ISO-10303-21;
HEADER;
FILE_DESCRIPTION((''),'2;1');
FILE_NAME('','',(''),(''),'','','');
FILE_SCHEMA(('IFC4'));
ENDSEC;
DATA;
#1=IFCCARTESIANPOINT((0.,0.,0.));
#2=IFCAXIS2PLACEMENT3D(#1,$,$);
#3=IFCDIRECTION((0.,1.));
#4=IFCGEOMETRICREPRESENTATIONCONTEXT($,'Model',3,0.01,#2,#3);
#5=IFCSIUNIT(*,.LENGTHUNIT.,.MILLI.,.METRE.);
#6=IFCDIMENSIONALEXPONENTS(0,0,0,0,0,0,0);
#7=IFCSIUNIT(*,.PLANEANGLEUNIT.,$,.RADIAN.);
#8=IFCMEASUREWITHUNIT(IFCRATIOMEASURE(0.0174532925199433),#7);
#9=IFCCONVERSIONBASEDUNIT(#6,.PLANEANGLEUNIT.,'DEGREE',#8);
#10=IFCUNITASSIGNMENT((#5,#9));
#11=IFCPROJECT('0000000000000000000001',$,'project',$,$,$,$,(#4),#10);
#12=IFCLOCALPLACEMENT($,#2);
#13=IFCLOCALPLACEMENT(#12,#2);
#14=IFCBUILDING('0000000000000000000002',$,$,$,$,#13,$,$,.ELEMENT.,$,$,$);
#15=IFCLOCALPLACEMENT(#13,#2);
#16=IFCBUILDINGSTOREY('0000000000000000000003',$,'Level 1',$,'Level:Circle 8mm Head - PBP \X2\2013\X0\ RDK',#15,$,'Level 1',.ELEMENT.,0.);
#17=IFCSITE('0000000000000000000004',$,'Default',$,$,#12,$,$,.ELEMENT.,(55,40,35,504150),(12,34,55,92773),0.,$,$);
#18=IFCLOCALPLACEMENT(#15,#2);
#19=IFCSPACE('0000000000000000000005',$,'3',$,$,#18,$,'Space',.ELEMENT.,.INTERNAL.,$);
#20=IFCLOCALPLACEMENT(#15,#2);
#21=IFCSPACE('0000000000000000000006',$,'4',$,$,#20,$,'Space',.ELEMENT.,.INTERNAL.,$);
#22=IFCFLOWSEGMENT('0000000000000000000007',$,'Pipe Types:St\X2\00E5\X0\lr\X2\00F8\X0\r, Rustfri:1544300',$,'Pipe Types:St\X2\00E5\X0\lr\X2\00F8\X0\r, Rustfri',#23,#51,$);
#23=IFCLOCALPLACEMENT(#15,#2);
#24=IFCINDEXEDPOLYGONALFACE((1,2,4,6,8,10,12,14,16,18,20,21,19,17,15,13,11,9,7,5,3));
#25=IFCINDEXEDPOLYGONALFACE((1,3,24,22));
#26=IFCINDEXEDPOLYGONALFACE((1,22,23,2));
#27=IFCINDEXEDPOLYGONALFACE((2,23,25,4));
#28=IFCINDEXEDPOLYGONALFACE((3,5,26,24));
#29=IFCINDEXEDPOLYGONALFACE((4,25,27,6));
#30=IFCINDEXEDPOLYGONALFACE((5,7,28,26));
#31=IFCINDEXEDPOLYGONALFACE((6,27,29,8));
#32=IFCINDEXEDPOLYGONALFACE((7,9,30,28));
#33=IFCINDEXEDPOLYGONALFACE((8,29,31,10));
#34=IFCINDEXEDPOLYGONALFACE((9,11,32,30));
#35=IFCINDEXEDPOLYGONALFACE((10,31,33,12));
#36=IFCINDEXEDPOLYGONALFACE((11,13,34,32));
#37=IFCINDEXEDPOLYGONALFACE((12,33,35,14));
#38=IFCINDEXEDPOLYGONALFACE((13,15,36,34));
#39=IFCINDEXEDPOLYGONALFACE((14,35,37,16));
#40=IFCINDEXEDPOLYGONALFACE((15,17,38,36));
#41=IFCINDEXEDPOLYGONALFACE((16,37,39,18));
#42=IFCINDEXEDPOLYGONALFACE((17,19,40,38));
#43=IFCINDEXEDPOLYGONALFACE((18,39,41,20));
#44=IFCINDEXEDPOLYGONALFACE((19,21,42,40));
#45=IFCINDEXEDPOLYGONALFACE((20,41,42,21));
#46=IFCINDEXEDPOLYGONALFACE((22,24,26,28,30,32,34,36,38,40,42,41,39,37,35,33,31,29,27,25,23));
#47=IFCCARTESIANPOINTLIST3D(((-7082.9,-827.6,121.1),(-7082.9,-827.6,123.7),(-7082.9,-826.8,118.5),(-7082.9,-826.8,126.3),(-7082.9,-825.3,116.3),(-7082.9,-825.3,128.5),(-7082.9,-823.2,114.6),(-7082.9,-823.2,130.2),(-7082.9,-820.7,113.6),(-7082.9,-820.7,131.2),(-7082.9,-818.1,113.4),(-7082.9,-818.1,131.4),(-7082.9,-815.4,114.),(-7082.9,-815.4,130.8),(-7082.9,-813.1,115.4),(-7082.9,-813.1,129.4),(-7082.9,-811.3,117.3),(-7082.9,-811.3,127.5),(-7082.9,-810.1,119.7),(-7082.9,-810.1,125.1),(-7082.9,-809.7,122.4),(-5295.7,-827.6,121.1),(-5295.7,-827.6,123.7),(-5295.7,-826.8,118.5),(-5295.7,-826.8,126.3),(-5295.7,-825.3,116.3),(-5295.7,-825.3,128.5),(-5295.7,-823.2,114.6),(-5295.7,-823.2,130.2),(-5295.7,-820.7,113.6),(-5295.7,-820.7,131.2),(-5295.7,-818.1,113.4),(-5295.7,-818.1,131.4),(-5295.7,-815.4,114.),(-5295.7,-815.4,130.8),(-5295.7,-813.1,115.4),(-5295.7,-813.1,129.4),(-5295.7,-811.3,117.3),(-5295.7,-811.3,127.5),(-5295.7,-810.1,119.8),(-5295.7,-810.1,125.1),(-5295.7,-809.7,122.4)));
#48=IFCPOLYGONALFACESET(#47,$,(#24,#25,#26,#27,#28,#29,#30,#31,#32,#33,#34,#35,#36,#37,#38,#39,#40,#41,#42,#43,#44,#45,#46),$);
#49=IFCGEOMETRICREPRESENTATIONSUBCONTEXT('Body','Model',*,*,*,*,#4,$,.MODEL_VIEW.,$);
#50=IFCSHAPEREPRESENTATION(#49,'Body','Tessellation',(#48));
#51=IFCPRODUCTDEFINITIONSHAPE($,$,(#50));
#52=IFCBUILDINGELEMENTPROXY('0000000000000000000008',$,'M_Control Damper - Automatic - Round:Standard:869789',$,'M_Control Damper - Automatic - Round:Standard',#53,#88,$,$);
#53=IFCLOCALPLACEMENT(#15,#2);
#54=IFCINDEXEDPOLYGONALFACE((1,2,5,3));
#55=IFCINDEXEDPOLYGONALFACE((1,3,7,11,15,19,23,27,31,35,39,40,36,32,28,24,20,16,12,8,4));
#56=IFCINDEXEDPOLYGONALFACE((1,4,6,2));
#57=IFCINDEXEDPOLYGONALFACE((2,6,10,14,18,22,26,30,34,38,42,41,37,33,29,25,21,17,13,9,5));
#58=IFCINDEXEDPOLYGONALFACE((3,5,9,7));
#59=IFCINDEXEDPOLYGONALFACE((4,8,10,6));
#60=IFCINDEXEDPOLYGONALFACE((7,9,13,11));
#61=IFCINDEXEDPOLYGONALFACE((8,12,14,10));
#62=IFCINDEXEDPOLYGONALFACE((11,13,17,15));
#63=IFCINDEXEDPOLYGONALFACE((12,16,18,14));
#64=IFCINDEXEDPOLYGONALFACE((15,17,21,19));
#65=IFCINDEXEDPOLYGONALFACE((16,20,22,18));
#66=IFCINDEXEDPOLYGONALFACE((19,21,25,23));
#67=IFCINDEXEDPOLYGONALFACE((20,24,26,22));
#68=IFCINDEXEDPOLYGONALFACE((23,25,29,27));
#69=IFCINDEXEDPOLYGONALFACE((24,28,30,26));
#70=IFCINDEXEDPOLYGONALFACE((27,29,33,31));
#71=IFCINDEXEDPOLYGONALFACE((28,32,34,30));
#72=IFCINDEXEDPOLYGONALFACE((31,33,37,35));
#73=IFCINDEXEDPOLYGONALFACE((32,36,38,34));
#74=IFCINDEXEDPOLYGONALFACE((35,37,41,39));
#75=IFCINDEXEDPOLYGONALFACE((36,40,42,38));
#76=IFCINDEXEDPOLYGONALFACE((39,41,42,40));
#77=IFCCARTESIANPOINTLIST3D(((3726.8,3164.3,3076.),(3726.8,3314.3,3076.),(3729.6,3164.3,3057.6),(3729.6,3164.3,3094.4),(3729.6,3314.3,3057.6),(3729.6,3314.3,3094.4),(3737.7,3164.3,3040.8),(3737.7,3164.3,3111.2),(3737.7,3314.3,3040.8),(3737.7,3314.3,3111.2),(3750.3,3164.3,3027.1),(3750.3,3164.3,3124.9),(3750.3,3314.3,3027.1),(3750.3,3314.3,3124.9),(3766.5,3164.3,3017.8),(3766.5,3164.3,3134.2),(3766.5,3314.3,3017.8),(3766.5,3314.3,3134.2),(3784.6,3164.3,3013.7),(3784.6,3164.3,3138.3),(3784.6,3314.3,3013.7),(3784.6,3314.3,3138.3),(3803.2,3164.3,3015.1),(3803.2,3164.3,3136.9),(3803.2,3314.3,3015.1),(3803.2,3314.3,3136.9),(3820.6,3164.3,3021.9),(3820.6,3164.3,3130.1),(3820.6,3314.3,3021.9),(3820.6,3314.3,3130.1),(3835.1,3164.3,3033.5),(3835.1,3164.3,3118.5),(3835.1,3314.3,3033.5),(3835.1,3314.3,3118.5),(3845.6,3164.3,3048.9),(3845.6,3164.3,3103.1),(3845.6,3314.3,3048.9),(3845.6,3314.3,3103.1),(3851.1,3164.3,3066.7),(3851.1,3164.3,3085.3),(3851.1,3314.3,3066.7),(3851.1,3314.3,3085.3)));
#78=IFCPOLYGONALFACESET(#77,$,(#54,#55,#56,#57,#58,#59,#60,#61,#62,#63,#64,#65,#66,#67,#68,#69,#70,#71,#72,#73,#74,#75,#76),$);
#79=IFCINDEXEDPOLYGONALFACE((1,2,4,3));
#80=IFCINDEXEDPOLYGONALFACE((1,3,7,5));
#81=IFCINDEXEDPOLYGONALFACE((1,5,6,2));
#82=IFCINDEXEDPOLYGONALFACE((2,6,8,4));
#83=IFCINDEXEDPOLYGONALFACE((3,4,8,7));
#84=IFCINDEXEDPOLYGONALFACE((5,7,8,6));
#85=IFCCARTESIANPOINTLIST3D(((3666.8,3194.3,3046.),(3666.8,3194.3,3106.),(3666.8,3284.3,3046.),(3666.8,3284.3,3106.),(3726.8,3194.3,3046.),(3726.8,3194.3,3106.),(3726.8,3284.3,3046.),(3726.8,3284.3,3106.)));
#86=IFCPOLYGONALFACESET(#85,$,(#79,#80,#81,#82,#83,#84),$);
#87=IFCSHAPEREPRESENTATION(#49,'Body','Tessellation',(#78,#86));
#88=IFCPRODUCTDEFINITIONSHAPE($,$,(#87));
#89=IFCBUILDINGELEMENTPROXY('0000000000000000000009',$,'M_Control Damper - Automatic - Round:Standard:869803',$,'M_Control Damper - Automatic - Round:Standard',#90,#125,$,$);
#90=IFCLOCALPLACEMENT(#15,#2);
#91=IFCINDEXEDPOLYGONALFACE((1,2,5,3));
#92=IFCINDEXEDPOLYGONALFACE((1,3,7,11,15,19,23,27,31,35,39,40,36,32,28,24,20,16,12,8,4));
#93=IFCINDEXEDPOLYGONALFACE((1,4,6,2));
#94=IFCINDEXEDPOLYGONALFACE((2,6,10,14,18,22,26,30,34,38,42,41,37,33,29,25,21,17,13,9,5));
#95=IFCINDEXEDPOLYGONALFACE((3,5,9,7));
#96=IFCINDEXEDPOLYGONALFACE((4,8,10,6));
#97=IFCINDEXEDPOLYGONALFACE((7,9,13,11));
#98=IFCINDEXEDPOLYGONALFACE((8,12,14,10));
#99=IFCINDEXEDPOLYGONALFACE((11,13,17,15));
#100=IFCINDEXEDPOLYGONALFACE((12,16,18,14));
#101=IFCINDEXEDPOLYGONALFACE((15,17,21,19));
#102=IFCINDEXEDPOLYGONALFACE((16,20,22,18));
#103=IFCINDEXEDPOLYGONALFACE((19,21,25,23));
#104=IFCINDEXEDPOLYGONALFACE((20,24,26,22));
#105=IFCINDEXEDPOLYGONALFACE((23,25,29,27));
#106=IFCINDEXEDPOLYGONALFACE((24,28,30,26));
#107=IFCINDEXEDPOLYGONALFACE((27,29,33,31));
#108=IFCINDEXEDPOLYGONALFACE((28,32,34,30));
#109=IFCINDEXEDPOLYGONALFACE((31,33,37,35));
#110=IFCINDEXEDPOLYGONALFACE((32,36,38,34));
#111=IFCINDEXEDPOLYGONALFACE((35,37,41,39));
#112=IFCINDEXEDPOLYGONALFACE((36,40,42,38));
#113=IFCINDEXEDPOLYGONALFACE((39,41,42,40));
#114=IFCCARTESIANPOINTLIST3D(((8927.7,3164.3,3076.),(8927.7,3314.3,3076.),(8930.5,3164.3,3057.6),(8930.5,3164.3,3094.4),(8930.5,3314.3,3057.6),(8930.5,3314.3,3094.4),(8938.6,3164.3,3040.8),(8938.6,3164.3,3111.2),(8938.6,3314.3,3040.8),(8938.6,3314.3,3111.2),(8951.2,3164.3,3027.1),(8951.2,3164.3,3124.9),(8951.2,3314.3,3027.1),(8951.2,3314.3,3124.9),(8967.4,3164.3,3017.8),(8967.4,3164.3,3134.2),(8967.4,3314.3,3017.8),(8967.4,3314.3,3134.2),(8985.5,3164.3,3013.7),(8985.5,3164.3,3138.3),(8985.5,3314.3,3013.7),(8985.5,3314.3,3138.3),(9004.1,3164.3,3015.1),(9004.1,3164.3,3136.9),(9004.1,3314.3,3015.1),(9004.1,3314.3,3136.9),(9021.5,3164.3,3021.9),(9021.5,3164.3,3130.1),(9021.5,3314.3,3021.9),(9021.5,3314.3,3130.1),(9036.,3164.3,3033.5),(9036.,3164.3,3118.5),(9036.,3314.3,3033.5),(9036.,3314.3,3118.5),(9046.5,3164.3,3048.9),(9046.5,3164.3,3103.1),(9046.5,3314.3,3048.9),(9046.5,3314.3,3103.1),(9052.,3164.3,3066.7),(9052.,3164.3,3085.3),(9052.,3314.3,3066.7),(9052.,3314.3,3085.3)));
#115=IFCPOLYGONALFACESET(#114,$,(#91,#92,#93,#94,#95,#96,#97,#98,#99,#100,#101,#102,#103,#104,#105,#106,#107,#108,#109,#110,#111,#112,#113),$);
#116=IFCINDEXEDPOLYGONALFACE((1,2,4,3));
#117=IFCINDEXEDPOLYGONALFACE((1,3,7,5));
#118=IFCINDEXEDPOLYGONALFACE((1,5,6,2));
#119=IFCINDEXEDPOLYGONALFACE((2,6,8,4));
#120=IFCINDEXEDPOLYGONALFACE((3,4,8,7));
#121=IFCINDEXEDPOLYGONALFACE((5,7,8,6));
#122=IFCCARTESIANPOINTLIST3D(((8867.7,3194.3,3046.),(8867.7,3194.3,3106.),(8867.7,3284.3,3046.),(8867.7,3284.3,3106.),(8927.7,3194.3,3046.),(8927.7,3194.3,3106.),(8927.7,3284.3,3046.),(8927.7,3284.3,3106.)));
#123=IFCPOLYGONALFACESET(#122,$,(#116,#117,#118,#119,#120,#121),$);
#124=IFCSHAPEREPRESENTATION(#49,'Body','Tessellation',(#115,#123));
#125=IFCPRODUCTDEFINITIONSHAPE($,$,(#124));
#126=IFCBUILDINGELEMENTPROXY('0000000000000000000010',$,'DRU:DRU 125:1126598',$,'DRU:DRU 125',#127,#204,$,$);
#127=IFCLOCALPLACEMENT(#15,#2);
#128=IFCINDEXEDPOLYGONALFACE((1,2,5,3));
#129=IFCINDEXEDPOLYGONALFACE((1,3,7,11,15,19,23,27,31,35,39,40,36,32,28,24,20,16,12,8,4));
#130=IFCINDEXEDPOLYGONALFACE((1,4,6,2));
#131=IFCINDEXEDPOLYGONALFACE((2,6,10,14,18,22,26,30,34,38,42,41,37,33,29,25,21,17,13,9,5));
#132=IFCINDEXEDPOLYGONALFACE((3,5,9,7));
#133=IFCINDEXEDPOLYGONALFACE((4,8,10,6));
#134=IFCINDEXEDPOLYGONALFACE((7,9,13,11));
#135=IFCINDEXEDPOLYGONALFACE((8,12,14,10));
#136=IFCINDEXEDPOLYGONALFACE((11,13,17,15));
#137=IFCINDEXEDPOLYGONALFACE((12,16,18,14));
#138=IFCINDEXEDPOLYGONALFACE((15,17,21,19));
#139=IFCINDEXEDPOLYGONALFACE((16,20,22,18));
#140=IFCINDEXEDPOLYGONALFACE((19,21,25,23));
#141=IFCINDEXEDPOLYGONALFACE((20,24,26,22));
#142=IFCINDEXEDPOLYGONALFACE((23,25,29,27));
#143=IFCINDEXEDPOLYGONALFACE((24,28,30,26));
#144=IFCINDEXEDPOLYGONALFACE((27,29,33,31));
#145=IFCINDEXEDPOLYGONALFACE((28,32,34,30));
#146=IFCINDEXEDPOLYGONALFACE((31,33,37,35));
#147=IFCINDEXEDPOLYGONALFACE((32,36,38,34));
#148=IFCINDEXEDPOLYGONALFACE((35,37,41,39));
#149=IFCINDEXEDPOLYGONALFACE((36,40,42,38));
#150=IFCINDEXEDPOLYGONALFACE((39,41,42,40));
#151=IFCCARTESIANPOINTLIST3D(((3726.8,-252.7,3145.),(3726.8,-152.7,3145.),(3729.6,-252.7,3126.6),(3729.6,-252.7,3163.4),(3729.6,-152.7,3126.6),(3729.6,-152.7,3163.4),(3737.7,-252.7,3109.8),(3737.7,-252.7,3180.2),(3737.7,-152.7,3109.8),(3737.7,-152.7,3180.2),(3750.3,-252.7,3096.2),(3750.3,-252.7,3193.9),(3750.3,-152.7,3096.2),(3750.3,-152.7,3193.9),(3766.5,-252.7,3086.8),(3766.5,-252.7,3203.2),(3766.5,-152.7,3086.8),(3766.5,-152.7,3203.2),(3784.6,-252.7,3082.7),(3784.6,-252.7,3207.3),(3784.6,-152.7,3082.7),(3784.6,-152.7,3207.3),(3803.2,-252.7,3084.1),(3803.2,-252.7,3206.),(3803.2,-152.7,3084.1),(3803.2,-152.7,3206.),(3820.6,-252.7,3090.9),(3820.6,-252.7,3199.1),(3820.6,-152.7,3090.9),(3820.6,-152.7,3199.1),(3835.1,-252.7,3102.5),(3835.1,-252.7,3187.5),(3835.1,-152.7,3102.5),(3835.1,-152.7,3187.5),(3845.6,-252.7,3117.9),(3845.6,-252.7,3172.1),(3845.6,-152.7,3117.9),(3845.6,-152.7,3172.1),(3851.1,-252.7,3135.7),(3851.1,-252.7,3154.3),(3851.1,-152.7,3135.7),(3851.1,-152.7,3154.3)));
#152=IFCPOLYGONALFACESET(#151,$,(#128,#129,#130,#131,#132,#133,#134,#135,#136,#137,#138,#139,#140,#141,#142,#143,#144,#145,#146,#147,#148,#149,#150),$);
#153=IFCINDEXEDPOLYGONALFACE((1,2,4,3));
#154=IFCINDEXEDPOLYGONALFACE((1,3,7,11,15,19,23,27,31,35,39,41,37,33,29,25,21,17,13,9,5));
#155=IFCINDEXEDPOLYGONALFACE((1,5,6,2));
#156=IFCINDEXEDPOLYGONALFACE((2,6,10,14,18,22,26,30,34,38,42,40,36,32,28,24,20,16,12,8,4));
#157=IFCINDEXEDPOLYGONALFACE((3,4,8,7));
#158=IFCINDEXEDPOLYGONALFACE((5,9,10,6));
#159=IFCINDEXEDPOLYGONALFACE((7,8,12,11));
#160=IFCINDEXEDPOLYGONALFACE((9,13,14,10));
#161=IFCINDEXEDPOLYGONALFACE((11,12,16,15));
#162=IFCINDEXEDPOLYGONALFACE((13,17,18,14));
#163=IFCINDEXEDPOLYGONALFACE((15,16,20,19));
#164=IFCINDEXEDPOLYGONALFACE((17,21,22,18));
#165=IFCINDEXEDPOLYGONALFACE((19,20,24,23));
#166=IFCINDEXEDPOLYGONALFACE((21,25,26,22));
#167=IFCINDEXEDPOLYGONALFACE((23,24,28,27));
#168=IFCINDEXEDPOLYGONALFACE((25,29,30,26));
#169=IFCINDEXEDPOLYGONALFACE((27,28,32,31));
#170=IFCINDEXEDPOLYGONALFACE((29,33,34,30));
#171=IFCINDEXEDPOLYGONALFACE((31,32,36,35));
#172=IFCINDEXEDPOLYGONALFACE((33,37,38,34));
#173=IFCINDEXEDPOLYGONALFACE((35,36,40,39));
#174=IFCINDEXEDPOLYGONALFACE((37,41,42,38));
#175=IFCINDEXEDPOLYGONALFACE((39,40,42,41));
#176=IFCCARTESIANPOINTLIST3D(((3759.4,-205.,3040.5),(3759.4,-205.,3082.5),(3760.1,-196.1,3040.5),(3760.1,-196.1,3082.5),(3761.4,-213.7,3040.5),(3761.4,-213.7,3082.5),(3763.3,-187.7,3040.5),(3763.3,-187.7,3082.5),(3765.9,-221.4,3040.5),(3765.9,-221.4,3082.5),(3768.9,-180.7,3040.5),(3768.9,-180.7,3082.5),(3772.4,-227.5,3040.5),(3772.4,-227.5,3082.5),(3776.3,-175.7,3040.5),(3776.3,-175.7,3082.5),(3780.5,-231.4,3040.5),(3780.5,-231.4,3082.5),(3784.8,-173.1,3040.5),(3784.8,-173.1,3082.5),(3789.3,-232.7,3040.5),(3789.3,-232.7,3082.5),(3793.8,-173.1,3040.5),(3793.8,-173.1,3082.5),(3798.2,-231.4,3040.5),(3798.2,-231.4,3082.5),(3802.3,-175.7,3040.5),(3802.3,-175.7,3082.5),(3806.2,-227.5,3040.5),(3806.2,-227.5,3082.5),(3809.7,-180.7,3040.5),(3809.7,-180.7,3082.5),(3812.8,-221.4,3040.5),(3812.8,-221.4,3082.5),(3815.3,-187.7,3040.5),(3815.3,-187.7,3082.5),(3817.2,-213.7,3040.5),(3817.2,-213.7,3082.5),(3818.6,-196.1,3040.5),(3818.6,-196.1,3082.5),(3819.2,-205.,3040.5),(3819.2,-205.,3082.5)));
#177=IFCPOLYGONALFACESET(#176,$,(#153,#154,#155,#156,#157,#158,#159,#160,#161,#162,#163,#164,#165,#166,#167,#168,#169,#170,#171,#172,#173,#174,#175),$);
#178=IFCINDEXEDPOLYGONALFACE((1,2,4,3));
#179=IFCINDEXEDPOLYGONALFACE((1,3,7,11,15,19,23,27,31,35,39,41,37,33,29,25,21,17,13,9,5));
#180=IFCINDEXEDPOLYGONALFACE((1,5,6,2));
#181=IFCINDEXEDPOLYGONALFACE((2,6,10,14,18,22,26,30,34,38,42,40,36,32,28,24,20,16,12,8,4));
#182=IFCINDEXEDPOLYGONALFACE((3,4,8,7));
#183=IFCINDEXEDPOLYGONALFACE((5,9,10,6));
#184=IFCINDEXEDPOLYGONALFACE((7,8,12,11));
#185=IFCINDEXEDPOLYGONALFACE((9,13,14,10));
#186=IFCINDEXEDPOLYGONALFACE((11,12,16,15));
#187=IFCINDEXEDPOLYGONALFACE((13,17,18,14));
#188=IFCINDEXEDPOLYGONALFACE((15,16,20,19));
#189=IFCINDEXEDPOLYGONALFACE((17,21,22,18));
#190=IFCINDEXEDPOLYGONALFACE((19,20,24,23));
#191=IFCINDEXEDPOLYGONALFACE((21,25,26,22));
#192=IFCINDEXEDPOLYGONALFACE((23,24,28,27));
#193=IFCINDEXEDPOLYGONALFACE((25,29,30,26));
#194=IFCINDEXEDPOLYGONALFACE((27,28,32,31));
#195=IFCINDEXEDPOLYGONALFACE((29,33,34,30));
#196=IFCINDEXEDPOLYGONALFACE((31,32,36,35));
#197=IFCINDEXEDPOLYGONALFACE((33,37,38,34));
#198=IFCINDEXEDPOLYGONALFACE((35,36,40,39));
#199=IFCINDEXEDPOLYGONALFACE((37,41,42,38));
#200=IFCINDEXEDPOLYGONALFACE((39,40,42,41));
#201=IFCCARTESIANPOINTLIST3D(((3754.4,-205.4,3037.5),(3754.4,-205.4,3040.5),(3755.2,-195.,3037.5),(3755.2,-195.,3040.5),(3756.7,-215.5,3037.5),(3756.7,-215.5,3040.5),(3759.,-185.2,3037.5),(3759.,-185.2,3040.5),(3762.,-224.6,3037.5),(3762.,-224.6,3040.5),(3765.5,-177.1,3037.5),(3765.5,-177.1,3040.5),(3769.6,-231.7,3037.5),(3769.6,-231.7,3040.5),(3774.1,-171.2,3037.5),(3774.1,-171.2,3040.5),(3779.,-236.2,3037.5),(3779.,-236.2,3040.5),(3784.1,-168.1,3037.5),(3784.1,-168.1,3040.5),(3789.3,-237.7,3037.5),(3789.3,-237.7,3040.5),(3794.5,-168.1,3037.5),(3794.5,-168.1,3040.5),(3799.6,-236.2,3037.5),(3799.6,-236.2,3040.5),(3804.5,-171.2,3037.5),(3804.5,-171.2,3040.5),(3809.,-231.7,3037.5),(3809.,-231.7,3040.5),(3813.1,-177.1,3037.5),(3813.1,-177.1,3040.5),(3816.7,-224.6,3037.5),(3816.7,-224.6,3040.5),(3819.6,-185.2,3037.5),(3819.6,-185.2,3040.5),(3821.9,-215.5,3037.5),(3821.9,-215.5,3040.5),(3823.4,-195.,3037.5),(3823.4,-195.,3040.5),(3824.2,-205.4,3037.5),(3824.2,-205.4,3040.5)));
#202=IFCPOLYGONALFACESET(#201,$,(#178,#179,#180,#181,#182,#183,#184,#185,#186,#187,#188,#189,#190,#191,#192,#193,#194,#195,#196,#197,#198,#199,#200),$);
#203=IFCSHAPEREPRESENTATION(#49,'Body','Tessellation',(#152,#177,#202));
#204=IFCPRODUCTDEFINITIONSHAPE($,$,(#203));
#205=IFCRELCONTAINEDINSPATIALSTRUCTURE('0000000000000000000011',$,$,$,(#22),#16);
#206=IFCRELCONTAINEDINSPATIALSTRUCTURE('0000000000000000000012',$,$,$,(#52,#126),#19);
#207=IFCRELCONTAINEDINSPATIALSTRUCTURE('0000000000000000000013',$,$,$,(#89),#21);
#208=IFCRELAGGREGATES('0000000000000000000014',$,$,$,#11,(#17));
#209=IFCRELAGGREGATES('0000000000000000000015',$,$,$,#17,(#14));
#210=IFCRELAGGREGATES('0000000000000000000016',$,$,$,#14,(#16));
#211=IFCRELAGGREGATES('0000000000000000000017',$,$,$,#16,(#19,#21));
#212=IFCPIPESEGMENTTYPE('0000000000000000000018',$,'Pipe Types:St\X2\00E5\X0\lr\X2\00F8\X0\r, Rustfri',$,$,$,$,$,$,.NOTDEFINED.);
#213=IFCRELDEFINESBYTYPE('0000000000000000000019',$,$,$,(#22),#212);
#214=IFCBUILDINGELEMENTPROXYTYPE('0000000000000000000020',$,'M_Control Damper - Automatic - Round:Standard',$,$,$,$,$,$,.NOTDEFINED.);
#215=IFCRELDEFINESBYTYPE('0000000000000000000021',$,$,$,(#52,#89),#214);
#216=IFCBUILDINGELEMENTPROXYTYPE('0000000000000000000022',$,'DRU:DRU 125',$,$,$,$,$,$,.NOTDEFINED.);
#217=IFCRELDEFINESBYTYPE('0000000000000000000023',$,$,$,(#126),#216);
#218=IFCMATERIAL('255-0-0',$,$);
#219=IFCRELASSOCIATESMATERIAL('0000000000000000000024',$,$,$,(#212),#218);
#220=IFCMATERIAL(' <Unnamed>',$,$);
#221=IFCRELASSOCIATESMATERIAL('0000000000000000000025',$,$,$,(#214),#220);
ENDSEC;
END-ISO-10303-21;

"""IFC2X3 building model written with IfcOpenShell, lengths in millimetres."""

from ifc_helpers import new_model, entity, si_unit, converted_unit, direction, frame, frame_2d, origin, place, context, subcontext, project, spatial, rectangle, circle, extrude, source, transform, mapped, material, type_object, type_shapes, element, save


model = new_model("IFC2X3")

# Units and contexts
model_context = context("Model", 3, precision=0.01, world=origin(), true_north=direction((0.0, 1.0)))
body_context = subcontext(model_context, "Body", "Model", "MODEL_VIEW")
ifc_project = project(units=[si_unit("LENGTHUNIT", "METRE", prefix="MILLI"), converted_unit("PLANEANGLEUNIT", "DEGREE", entity("IfcRatioMeasure", 0.0174532925199433), si_unit("PLANEANGLEUNIT", "RADIAN"), dimensions=[0, 0, 0, 0, 0, 0, 0])], contexts=[model_context])

# Site, building, storey, space
site_placement = place(None, origin())
site = spatial("IfcSite", under=ifc_project, at=site_placement, Name="Default", CompositionType="ELEMENT", RefLatitude=(55, 40, 35, 504150), RefLongitude=(12, 34, 55, 92773), RefElevation=0.0)
building_placement = place(site_placement, origin())
building = spatial("IfcBuilding", under=site, at=building_placement, CompositionType="ELEMENT")
storey_placement = place(building_placement, origin())
storey = spatial("IfcBuildingStorey", under=building, at=storey_placement, Name="Level 1", ObjectType="Level:Circle 8mm Head - PBP – RDK", LongName="Level 1", CompositionType="ELEMENT", Elevation=0.0)
space_1_placement = place(storey_placement, origin())
space_1 = spatial("IfcSpace", under=storey, at=space_1_placement, Name="3", LongName="Space", CompositionType="ELEMENT", InteriorOrExteriorSpace="INTERNAL")

# Shared definitions
space_2_placement = place(storey_placement, origin())
space_2 = spatial("IfcSpace", under=storey, at=space_2_placement, Name="4", LongName="Space", CompositionType="ELEMENT", InteriorOrExteriorSpace="INTERNAL")

# Flow segment
ifc_material_1 = material(Name="255-0-0")
pipe_segment_type = type_object("IfcPipeSegmentType", Name="Pipe Types:Stålrør, Rustfri", PredefinedType="NOTDEFINED", material=ifc_material_1)
flow_segment_1_placement = place(storey_placement, origin())
element("IfcFlowSegment", 1, at=flow_segment_1_placement, inside=storey, type_object=pipe_segment_type, Name="Pipe Types:Stålrør, Rustfri:1544300", ObjectType="Pipe Types:Stålrør, Rustfri", context=body_context, shape_type="SweptSolid", body=[
    extrude(circle(Radius=9.0, at=frame_2d((0.0, 0.0), x_axis=(1.0, 0.0))), frame((-7082.9, -818.7, 122.4), z_axis=(1.0, 0.0, 0.000004), x_axis=(0.0, 1.0, 0.0)), (0.0, 0.0, 1.0), 1787.2),
])

# Building element proxies
ifc_material_2 = material(Name=" <Unnamed>")
building_element_proxy_type_1 = type_object("IfcBuildingElementProxyType", Name="M_Control Damper - Automatic - Round:Standard", PredefinedType="NOTDEFINED", material=ifc_material_2)
shared_shape_1 = source(origin(), body_context, "Body", "SweptSolid", [
    extrude(circle(Radius=62.5, at=frame_2d((0.0, 0.0), x_axis=(1.0, 0.0))), frame((-75.0, 0.0, 0.0), z_axis=(1.0, 0.0, 0.0), x_axis=(0.0, 1.0, 0.0)), (0.0, 0.0, 1.0), 150.0),
    extrude(rectangle(XDim=90.0, YDim=60.0, at=frame_2d((0.0, 0.0), x_axis=(1.0, 0.0))), frame((0.0, 92.5, -30.0), z_axis=(0.0, 0.0, 1.0), x_axis=(-1.0, 0.0, 0.0)), (0.0, 0.0, 1.0), 60.0),
])
type_shapes(building_element_proxy_type_1, [shared_shape_1])
proxy_1_placement = place(space_1_placement, frame((3789.3, 3239.3, 3076.0), z_axis=(0.0, 0.0, -1.0), x_axis=(0.0, -1.0, 0.0)))
element("IfcBuildingElementProxy", 2, at=proxy_1_placement, inside=space_1, type_object=building_element_proxy_type_1, Name="M_Control Damper - Automatic - Round:Standard:869789", ObjectType="M_Control Damper - Automatic - Round:Standard", context=body_context, shape_type="MappedRepresentation", body=[
    mapped(shared_shape_1, transform((0.0, 0.0, 0.0), scale=1.0)),
])
proxy_2_placement = place(space_2_placement, frame((8990.2, 3239.3, 3076.0), z_axis=(0.0, 0.0, -1.0), x_axis=(0.0, -1.0, 0.0)))
element("IfcBuildingElementProxy", 3, at=proxy_2_placement, inside=space_2, type_object=building_element_proxy_type_1, Name="M_Control Damper - Automatic - Round:Standard:869803", ObjectType="M_Control Damper - Automatic - Round:Standard", context=body_context, shape_type="MappedRepresentation", body=[
    mapped(shared_shape_1, transform((0.0, 0.0, 0.0), scale=1.0)),
])
building_element_proxy_type_2 = type_object("IfcBuildingElementProxyType", Name="DRU:DRU 125", PredefinedType="NOTDEFINED")
shared_shape_2 = source(origin(), body_context, "Body", "SweptSolid", [
    extrude(circle(Radius=62.5, at=frame_2d((0.0, 0.0), x_axis=(1.0, 0.0))), frame((-50.0, 0.0, 0.0), z_axis=(1.0, 0.0, 0.0), x_axis=(0.0, 1.0, 0.0)), (0.0, 0.0, 1.0), 100.0),
    extrude(circle(Radius=30.0, at=frame_2d((0.0, 0.0), x_axis=(1.0, 0.0))), frame((0.0, 0.0, 62.5)), (0.0, 0.0, 1.0), 42.0),
    extrude(circle(Radius=35.0, at=frame_2d((0.0, 0.0), x_axis=(1.0, 0.0))), frame((0.0, 0.0, 104.5)), (0.0, 0.0, 1.0), 3.0),
])
type_shapes(building_element_proxy_type_2, [shared_shape_2])
proxy_3_placement = place(space_1_placement, frame((3789.3, -202.7, 3145.0), z_axis=(0.0, 0.0, -1.0), x_axis=(0.0, -1.0, 0.0)))
element("IfcBuildingElementProxy", 4, at=proxy_3_placement, inside=space_1, type_object=building_element_proxy_type_2, Name="DRU:DRU 125:1126598", ObjectType="DRU:DRU 125", context=body_context, shape_type="MappedRepresentation", body=[
    mapped(shared_shape_2, transform((0.0, 0.0, 0.0), scale=1.0)),
])

save(model, "model.ifc")
